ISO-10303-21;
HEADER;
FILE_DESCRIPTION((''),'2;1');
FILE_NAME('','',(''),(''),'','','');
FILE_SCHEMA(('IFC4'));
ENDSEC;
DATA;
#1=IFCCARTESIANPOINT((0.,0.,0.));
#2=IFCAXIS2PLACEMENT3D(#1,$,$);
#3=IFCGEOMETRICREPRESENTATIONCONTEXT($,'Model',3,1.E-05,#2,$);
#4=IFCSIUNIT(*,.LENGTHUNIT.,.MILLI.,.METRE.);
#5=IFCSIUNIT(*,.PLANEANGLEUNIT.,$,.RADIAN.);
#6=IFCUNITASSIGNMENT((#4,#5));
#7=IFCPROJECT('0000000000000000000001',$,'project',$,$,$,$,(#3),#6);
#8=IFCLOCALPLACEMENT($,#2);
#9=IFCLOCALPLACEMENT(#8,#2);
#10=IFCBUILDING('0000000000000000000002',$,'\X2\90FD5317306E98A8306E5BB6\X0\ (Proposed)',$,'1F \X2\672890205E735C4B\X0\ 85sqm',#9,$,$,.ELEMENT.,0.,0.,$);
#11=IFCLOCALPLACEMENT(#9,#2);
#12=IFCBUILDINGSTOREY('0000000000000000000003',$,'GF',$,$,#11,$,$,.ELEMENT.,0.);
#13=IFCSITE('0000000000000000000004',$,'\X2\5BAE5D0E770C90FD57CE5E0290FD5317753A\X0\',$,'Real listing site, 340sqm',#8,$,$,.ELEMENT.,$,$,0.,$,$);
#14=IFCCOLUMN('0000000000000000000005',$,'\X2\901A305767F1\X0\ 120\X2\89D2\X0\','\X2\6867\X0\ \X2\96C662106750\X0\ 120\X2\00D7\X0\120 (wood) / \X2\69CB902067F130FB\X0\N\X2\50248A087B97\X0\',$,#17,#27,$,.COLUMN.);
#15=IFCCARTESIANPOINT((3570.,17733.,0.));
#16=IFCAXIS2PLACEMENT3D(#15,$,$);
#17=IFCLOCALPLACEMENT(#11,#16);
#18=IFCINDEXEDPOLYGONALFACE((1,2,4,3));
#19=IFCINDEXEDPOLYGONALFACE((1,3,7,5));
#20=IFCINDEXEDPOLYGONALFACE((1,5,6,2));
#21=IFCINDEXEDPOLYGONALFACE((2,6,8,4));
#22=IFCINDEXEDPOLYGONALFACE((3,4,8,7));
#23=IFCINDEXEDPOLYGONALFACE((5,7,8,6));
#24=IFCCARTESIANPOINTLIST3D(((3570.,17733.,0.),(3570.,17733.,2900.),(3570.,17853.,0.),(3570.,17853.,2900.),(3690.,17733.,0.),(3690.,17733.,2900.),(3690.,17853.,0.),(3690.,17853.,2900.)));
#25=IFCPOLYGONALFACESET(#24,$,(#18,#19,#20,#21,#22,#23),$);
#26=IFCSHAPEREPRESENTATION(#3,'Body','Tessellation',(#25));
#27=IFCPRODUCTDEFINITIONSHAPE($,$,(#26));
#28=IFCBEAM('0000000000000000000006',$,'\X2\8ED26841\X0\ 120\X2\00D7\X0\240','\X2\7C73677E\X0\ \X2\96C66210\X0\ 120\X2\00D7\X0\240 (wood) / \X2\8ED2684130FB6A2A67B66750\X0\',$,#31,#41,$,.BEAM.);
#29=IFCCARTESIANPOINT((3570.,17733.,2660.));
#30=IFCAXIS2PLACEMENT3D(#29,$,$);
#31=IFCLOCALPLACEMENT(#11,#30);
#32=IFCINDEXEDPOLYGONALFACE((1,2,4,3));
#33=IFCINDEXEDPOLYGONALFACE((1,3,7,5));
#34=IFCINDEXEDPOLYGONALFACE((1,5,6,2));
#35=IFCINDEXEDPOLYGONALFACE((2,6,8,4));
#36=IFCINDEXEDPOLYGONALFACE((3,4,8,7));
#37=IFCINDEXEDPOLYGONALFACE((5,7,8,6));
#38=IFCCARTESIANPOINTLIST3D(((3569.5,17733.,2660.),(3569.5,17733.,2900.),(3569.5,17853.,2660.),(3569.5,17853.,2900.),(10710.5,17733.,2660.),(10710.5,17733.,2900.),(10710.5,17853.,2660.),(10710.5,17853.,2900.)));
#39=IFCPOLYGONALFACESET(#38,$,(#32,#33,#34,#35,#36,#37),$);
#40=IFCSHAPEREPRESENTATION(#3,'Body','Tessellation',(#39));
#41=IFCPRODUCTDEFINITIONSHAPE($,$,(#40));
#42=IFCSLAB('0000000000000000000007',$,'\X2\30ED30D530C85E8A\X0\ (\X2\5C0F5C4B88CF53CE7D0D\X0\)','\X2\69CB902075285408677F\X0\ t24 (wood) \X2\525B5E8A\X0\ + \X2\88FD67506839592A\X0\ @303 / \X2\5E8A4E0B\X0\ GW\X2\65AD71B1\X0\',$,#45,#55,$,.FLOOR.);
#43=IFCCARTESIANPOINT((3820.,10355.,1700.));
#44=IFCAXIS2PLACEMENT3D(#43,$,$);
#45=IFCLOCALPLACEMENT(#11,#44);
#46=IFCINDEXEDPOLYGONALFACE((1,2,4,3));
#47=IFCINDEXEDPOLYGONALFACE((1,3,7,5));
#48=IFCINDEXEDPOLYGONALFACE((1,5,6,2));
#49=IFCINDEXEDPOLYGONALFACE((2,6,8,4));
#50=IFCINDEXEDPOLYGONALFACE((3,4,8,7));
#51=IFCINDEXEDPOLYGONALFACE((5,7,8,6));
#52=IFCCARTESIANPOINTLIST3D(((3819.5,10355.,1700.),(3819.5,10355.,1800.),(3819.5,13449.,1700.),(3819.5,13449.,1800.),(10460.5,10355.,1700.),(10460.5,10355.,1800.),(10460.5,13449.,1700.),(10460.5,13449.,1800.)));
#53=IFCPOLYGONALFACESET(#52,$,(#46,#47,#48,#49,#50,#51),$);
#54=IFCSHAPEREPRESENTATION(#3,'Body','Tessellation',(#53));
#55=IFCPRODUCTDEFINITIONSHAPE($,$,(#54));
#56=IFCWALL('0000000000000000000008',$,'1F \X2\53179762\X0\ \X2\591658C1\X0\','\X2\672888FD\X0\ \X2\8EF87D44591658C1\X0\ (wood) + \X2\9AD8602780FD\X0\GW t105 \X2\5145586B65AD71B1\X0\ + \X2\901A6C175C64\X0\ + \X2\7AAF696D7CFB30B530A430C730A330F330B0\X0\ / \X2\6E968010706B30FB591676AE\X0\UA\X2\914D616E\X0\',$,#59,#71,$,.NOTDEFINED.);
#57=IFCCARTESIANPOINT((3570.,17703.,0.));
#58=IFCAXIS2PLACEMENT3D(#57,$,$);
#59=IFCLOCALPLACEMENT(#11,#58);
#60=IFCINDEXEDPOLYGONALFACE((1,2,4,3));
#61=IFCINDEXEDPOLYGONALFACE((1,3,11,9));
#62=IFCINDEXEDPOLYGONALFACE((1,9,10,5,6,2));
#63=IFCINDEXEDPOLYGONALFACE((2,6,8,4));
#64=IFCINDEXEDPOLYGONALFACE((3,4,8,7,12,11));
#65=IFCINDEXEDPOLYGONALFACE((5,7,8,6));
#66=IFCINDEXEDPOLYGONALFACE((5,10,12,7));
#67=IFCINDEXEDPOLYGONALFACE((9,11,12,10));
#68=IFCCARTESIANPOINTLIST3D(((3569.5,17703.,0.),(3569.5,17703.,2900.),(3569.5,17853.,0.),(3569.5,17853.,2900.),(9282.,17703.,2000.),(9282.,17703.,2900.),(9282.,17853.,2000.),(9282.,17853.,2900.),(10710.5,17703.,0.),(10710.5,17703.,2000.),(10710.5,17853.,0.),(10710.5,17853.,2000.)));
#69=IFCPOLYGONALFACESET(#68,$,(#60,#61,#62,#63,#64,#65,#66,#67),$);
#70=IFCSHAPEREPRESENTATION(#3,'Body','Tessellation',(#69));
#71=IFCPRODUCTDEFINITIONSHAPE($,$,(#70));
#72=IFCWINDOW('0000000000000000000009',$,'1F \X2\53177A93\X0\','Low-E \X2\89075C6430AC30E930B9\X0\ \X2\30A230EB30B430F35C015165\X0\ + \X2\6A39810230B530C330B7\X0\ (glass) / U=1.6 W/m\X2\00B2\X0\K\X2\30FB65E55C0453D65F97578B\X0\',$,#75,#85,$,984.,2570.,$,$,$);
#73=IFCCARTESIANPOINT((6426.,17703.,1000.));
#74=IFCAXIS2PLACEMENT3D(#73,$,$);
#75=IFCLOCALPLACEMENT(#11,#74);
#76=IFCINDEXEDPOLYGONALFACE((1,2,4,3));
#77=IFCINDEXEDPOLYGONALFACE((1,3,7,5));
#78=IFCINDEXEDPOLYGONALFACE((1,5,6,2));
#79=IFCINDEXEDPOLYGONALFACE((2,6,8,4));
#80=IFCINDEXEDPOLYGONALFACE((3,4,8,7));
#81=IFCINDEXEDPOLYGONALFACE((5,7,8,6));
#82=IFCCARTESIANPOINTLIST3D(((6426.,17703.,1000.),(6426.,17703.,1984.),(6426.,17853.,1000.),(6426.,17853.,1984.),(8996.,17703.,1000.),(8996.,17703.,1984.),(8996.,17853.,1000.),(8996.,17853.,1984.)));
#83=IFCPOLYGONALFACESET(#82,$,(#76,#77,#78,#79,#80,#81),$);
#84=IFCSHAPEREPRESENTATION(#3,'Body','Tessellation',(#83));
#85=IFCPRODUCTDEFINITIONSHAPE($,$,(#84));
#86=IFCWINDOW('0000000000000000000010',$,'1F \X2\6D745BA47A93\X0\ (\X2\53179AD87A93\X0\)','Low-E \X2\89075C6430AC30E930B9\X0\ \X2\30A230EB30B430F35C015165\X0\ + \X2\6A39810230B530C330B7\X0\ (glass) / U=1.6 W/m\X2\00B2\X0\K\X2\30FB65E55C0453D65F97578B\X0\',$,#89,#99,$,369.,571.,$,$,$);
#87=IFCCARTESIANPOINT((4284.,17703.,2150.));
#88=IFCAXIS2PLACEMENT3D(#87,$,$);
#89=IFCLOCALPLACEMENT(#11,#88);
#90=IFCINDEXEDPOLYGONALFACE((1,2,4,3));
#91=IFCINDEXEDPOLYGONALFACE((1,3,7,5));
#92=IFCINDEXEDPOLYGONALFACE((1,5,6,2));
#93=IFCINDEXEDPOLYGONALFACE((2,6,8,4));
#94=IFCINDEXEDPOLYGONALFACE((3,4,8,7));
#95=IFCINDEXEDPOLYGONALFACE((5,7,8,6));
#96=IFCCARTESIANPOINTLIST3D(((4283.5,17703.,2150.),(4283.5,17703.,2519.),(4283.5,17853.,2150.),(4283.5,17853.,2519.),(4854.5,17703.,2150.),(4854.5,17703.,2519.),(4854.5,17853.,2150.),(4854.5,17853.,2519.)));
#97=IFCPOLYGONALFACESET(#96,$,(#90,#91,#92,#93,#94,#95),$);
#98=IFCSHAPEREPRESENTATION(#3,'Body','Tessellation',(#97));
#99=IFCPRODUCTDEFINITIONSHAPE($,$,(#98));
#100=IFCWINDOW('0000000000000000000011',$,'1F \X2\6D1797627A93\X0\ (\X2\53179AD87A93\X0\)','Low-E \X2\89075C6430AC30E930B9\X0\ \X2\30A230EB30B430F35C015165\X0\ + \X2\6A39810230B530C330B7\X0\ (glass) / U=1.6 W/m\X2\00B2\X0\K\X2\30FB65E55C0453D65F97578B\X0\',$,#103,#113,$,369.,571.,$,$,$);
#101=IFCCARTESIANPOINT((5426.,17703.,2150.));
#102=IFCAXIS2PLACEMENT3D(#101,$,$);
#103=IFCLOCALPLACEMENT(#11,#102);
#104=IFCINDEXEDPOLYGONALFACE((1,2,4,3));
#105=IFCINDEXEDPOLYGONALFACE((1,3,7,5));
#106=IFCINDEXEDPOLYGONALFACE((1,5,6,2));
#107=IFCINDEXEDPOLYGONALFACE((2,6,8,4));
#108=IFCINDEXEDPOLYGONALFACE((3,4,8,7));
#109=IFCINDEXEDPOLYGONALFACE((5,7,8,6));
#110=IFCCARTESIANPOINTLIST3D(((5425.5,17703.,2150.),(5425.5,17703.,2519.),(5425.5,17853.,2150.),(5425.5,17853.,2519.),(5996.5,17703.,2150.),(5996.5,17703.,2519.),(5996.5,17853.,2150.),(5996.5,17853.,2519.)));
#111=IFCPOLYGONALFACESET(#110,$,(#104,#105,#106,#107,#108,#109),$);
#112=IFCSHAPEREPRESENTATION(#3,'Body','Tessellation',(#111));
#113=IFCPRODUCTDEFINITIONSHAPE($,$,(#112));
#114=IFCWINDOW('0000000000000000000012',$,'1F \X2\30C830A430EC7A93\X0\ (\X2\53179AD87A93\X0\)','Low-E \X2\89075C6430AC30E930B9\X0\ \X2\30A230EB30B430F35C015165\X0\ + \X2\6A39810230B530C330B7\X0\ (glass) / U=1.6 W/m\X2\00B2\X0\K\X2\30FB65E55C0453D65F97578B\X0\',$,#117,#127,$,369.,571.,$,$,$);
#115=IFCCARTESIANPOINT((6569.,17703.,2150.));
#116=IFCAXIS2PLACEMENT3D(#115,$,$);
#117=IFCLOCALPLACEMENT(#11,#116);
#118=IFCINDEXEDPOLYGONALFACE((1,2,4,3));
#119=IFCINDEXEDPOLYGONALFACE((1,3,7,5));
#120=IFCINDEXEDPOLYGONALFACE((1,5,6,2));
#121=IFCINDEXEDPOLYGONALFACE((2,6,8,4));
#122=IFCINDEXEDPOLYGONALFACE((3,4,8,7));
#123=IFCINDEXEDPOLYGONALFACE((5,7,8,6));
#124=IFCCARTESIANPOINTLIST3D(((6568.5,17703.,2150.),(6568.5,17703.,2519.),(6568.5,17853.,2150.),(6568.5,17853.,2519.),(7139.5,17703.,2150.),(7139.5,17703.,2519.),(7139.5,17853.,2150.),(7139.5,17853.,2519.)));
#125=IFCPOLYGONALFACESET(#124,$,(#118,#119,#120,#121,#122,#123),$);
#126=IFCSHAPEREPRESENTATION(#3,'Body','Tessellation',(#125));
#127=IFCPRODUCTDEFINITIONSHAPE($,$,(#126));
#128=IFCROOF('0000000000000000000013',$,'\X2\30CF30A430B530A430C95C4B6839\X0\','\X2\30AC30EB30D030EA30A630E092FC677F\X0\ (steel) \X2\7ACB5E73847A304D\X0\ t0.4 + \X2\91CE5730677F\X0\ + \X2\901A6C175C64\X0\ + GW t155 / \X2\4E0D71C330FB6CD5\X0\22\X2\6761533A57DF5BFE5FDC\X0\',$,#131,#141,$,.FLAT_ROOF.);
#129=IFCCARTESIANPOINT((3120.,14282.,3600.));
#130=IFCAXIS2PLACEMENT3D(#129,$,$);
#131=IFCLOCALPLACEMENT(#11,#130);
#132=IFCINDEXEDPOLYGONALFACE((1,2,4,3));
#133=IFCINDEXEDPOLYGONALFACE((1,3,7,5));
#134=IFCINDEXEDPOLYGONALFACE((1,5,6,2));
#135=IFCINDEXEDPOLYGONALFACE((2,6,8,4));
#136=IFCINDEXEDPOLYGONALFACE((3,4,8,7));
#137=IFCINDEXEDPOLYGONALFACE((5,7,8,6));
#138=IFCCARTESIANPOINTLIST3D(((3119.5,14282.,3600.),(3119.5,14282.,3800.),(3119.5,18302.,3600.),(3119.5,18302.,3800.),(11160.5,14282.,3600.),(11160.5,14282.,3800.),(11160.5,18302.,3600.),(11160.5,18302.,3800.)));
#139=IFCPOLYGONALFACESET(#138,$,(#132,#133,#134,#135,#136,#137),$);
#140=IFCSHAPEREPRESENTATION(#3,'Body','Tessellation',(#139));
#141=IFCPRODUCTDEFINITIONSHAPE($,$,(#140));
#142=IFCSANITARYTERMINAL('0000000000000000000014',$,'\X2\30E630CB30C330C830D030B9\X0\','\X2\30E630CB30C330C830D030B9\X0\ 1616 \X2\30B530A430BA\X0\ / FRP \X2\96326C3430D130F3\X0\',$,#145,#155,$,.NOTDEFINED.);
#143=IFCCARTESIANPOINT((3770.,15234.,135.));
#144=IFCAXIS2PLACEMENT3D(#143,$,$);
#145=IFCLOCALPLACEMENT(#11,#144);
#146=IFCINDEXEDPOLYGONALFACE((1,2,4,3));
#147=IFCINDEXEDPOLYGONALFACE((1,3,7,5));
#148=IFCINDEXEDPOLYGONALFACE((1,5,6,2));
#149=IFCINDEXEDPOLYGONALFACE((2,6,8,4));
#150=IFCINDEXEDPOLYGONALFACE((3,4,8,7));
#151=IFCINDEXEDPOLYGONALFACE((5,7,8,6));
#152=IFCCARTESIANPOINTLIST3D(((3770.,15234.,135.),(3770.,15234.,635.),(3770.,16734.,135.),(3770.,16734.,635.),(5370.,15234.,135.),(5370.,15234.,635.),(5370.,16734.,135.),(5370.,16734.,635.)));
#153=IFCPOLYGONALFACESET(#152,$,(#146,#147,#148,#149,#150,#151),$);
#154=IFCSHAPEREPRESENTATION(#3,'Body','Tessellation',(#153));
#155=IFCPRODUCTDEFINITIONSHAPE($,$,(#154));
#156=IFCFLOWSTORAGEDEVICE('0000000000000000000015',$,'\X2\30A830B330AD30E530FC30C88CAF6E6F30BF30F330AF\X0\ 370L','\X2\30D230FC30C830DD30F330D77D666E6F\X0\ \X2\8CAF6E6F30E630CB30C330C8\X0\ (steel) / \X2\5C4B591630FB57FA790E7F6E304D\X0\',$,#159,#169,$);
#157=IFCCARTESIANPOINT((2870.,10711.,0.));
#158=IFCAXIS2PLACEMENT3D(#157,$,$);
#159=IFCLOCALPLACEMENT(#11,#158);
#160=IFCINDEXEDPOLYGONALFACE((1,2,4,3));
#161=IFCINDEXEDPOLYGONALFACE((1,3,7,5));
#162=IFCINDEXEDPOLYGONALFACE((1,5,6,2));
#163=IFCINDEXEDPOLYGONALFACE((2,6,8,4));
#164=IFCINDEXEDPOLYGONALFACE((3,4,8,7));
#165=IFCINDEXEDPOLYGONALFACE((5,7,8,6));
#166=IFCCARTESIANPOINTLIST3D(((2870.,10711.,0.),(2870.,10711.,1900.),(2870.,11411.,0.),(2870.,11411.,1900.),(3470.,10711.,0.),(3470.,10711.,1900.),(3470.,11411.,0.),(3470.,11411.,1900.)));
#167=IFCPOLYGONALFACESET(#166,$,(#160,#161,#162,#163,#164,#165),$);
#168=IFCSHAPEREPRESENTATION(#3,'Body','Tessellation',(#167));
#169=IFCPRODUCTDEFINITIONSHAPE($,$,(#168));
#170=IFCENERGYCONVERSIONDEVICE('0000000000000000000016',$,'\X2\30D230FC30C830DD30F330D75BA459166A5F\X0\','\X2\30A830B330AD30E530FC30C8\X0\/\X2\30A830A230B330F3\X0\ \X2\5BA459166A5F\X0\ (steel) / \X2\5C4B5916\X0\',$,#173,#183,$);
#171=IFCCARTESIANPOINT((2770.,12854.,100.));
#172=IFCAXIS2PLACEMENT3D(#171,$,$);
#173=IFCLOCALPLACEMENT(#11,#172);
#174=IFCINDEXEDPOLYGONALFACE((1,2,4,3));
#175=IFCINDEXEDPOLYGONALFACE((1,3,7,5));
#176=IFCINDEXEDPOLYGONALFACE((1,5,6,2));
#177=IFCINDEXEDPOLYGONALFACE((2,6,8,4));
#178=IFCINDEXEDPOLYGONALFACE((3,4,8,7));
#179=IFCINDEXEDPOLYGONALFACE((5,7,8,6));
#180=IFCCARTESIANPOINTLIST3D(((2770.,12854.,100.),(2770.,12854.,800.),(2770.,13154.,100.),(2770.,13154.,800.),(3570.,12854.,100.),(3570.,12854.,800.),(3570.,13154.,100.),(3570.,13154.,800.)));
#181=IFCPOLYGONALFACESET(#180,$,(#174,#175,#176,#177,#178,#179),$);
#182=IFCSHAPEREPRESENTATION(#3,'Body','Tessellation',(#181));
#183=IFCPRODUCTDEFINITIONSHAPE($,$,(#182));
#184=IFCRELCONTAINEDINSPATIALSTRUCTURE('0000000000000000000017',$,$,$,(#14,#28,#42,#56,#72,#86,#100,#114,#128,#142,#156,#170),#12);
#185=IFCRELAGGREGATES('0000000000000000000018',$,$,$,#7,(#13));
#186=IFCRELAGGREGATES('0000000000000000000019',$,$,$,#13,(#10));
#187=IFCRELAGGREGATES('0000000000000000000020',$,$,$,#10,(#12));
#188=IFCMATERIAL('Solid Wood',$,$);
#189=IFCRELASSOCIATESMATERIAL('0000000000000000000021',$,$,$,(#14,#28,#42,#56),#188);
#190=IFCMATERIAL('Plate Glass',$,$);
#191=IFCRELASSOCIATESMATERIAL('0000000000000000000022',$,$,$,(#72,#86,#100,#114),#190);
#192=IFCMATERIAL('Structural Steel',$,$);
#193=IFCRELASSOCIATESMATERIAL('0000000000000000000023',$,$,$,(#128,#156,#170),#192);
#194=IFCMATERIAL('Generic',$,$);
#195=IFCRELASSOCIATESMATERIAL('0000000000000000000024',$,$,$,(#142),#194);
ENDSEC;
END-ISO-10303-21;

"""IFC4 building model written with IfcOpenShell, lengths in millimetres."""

from ifc_helpers import new_model, si_unit, frame, frame_2d, origin, place, context, project, spatial, rectangle, extrude, material, element, fill, save


model = new_model("IFC4")

# Units and contexts
model_context = context("Model", 3, precision=1e-05, world=origin())
ifc_project = project(units=[si_unit("LENGTHUNIT", "METRE", prefix="MILLI"), si_unit("PLANEANGLEUNIT", "RADIAN")], contexts=[model_context])

# Site, building, storey
site_placement = place(None, origin())
site = spatial("IfcSite", under=ifc_project, at=site_placement, Name="宮崎県都城市都北町", ObjectType="Real listing site, 340sqm", CompositionType="ELEMENT", RefElevation=0.0)
building_placement = place(site_placement, origin())
building = spatial("IfcBuilding", under=site, at=building_placement, Name="都北の風の家 (Proposed)", ObjectType="1F 木造平屋 85sqm", CompositionType="ELEMENT", ElevationOfRefHeight=0.0, ElevationOfTerrain=0.0)
storey_placement = place(building_placement, origin())
storey = spatial("IfcBuildingStorey", under=building, at=storey_placement, Name="GF", CompositionType="ELEMENT", Elevation=0.0)

# Column
ifc_material_1 = material(Name="Solid Wood")
column_1_placement = place(storey_placement, frame((3570.0, 17733.0, 0.0)))
element("IfcColumn", 1, at=column_1_placement, inside=storey, material=ifc_material_1, Name="通し柱 120角", Description="桧 集成材 120×120 (wood) / 構造柱・N値計算", PredefinedType="COLUMN", context=model_context, shape_type="SweptSolid", body=[
    extrude(rectangle(XDim=120.0, YDim=120.0, at=frame_2d((60.0, 60.0))), frame((3570.0, 17733.0, 0.0)), (0.0, 0.0, 1.0), 2900.0),
])

# Beam
beam_1_placement = place(storey_placement, frame((3570.0, 17733.0, 2660.0)))
element("IfcBeam", 2, at=beam_1_placement, inside=storey, material=ifc_material_1, Name="軒桁 120×240", Description="米松 集成 120×240 (wood) / 軒桁・横架材", PredefinedType="BEAM", context=model_context, shape_type="SweptSolid", body=[
    extrude(rectangle(XDim=7141.0, YDim=120.0, at=frame_2d((3570.0, 60.0))), frame((3570.0, 17733.0, 2660.0)), (0.0, 0.0, 1.0), 240.0),
])

# Slab
slab_placement = place(storey_placement, frame((3820.0, 10355.0, 1700.0)))
element("IfcSlab", 3, at=slab_placement, inside=storey, material=ifc_material_1, Name="ロフト床 (小屋裏収納)", Description="構造用合板 t24 (wood) 剛床 + 製材根太 @303 / 床下 GW断熱", PredefinedType="FLOOR", context=model_context, shape_type="SweptSolid", body=[
    extrude(rectangle(XDim=6641.0, YDim=3094.0, at=frame_2d((3320.0, 1547.0))), frame((3820.0, 10355.0, 1700.0)), (0.0, 0.0, 1.0), 100.0),
])

# Wall, openings, windows
wall_1_placement = place(storey_placement, frame((3570.0, 17703.0, 0.0)))
wall_1 = element("IfcWall", 4, at=wall_1_placement, inside=storey, material=ifc_material_1, Name="1F 北面 外壁", Description="木製 軸組外壁 (wood) + 高性能GW t105 充填断熱 + 通気層 + 窯業系サイディング / 準耐火・外皮UA配慮", PredefinedType="NOTDEFINED", context=model_context, shape_type="SweptSolid", body=[
    extrude(rectangle(XDim=7141.0, YDim=150.0, at=frame_2d((3570.0, 75.0))), frame((3570.0, 17703.0, 0.0)), (0.0, 0.0, 1.0), 2900.0),
])
opening_1_placement = place(storey_placement, frame((6426.0, 17703.0, 1000.0)))
opening_1 = element("IfcOpeningElement", 5, at=opening_1_placement, cuts=wall_1, PredefinedType="NOTDEFINED", context=model_context, shape_type="SweptSolid", body=[
    extrude(rectangle(XDim=2570.0, YDim=150.0, at=frame_2d((1285.0, 75.0))), frame((6426.0, 17703.0, 1000.0)), (0.0, 0.0, 1.0), 984.0),
])
opening_2_placement = place(storey_placement, frame((4284.0, 17703.0, 2150.0)))
opening_2 = element("IfcOpeningElement", 6, at=opening_2_placement, cuts=wall_1, PredefinedType="NOTDEFINED", context=model_context, shape_type="SweptSolid", body=[
    extrude(rectangle(XDim=571.0, YDim=150.0, at=frame_2d((285.0, 75.0))), frame((4284.0, 17703.0, 2150.0)), (0.0, 0.0, 1.0), 369.0),
])
opening_3_placement = place(storey_placement, frame((5426.0, 17703.0, 2150.0)))
opening_3 = element("IfcOpeningElement", 7, at=opening_3_placement, cuts=wall_1, PredefinedType="NOTDEFINED", context=model_context, shape_type="SweptSolid", body=[
    extrude(rectangle(XDim=571.0, YDim=150.0, at=frame_2d((285.0, 75.0))), frame((5426.0, 17703.0, 2150.0)), (0.0, 0.0, 1.0), 369.0),
])
opening_4_placement = place(storey_placement, frame((6569.0, 17703.0, 2150.0)))
opening_4 = element("IfcOpeningElement", 8, at=opening_4_placement, cuts=wall_1, PredefinedType="NOTDEFINED", context=model_context, shape_type="SweptSolid", body=[
    extrude(rectangle(XDim=571.0, YDim=150.0, at=frame_2d((285.0, 75.0))), frame((6569.0, 17703.0, 2150.0)), (0.0, 0.0, 1.0), 369.0),
])
ifc_material_2 = material(Name="Plate Glass")
window_1_placement = place(storey_placement, frame((6426.0, 17703.0, 1000.0)))
window_1 = element("IfcWindow", 9, at=window_1_placement, inside=storey, material=ifc_material_2, Name="1F 北窓", Description="Low-E 複層ガラス アルゴン封入 + 樹脂サッシ (glass) / U=1.6 W/m²K・日射取得型", OverallHeight=984.0, OverallWidth=2570.0, context=model_context, shape_type="SweptSolid", body=[
    extrude(rectangle(XDim=2570.0, YDim=150.0, at=frame_2d((1285.0, 75.0))), frame((6426.0, 17703.0, 1000.0)), (0.0, 0.0, 1.0), 984.0),
])
fill(opening_1, window_1)
window_2_placement = place(storey_placement, frame((4284.0, 17703.0, 2150.0)))
window_2 = element("IfcWindow", 10, at=window_2_placement, inside=storey, material=ifc_material_2, Name="1F 浴室窓 (北高窓)", Description="Low-E 複層ガラス アルゴン封入 + 樹脂サッシ (glass) / U=1.6 W/m²K・日射取得型", OverallHeight=369.0, OverallWidth=571.0, context=model_context, shape_type="SweptSolid", body=[
    extrude(rectangle(XDim=571.0, YDim=150.0, at=frame_2d((285.0, 75.0))), frame((4284.0, 17703.0, 2150.0)), (0.0, 0.0, 1.0), 369.0),
])
fill(opening_2, window_2)
window_3_placement = place(storey_placement, frame((5426.0, 17703.0, 2150.0)))
window_3 = element("IfcWindow", 11, at=window_3_placement, inside=storey, material=ifc_material_2, Name="1F 洗面窓 (北高窓)", Description="Low-E 複層ガラス アルゴン封入 + 樹脂サッシ (glass) / U=1.6 W/m²K・日射取得型", OverallHeight=369.0, OverallWidth=571.0, context=model_context, shape_type="SweptSolid", body=[
    extrude(rectangle(XDim=571.0, YDim=150.0, at=frame_2d((285.0, 75.0))), frame((5426.0, 17703.0, 2150.0)), (0.0, 0.0, 1.0), 369.0),
])
fill(opening_3, window_3)
window_4_placement = place(storey_placement, frame((6569.0, 17703.0, 2150.0)))
window_4 = element("IfcWindow", 12, at=window_4_placement, inside=storey, material=ifc_material_2, Name="1F トイレ窓 (北高窓)", Description="Low-E 複層ガラス アルゴン封入 + 樹脂サッシ (glass) / U=1.6 W/m²K・日射取得型", OverallHeight=369.0, OverallWidth=571.0, context=model_context, shape_type="SweptSolid", body=[
    extrude(rectangle(XDim=571.0, YDim=150.0, at=frame_2d((285.0, 75.0))), frame((6569.0, 17703.0, 2150.0)), (0.0, 0.0, 1.0), 369.0),
])
fill(opening_4, window_4)

# Roof
ifc_material_3 = material(Name="Structural Steel")
roof_placement = place(storey_placement, frame((3120.0, 14282.0, 3600.0)))
element("IfcRoof", 13, at=roof_placement, inside=storey, material=ifc_material_3, Name="ハイサイド屋根", Description="ガルバリウム鋼板 (steel) 立平葺き t0.4 + 野地板 + 通気層 + GW t155 / 不燃・法22条区域対応", PredefinedType="FLAT_ROOF", context=model_context, shape_type="SweptSolid", body=[
    extrude(rectangle(XDim=8041.0, YDim=4020.0, at=frame_2d((4020.0, 2010.0))), frame((3120.0, 14282.0, 3600.0)), (0.0, 0.0, 1.0), 200.0),
])

# Sanitary terminal
ifc_material_4 = material(Name="Generic")
sanitary_terminal_placement = place(storey_placement, frame((3770.0, 15234.0, 135.0)))
element("IfcSanitaryTerminal", 14, at=sanitary_terminal_placement, inside=storey, material=ifc_material_4, Name="ユニットバス", Description="ユニットバス 1616 サイズ / FRP 防水パン", PredefinedType="NOTDEFINED", context=model_context, shape_type="SweptSolid", body=[
    extrude(rectangle(XDim=1600.0, YDim=1500.0, at=frame_2d((800.0, 750.0))), frame((3770.0, 15234.0, 135.0)), (0.0, 0.0, 1.0), 500.0),
])

# Flow storage device
flow_storage_device_placement = place(storey_placement, frame((2870.0, 10711.0, 0.0)))
element("IfcFlowStorageDevice", 15, at=flow_storage_device_placement, inside=storey, material=ifc_material_3, Name="エコキュート貯湯タンク 370L", Description="ヒートポンプ給湯 貯湯ユニット (steel) / 屋外・基礎置き", context=model_context, shape_type="SweptSolid", body=[
    extrude(rectangle(XDim=600.0, YDim=700.0, at=frame_2d((300.0, 350.0))), frame((2870.0, 10711.0, 0.0)), (0.0, 0.0, 1.0), 1900.0),
])

# Energy conversion device
energy_conversion_device_placement = place(storey_placement, frame((2770.0, 12854.0, 100.0)))
element("IfcEnergyConversionDevice", 16, at=energy_conversion_device_placement, inside=storey, material=ifc_material_3, Name="ヒートポンプ室外機", Description="エコキュート/エアコン 室外機 (steel) / 屋外", context=model_context, shape_type="SweptSolid", body=[
    extrude(rectangle(XDim=800.0, YDim=300.0, at=frame_2d((400.0, 150.0))), frame((2770.0, 12854.0, 100.0)), (0.0, 0.0, 1.0), 700.0),
])

save(model, "model.ifc")
